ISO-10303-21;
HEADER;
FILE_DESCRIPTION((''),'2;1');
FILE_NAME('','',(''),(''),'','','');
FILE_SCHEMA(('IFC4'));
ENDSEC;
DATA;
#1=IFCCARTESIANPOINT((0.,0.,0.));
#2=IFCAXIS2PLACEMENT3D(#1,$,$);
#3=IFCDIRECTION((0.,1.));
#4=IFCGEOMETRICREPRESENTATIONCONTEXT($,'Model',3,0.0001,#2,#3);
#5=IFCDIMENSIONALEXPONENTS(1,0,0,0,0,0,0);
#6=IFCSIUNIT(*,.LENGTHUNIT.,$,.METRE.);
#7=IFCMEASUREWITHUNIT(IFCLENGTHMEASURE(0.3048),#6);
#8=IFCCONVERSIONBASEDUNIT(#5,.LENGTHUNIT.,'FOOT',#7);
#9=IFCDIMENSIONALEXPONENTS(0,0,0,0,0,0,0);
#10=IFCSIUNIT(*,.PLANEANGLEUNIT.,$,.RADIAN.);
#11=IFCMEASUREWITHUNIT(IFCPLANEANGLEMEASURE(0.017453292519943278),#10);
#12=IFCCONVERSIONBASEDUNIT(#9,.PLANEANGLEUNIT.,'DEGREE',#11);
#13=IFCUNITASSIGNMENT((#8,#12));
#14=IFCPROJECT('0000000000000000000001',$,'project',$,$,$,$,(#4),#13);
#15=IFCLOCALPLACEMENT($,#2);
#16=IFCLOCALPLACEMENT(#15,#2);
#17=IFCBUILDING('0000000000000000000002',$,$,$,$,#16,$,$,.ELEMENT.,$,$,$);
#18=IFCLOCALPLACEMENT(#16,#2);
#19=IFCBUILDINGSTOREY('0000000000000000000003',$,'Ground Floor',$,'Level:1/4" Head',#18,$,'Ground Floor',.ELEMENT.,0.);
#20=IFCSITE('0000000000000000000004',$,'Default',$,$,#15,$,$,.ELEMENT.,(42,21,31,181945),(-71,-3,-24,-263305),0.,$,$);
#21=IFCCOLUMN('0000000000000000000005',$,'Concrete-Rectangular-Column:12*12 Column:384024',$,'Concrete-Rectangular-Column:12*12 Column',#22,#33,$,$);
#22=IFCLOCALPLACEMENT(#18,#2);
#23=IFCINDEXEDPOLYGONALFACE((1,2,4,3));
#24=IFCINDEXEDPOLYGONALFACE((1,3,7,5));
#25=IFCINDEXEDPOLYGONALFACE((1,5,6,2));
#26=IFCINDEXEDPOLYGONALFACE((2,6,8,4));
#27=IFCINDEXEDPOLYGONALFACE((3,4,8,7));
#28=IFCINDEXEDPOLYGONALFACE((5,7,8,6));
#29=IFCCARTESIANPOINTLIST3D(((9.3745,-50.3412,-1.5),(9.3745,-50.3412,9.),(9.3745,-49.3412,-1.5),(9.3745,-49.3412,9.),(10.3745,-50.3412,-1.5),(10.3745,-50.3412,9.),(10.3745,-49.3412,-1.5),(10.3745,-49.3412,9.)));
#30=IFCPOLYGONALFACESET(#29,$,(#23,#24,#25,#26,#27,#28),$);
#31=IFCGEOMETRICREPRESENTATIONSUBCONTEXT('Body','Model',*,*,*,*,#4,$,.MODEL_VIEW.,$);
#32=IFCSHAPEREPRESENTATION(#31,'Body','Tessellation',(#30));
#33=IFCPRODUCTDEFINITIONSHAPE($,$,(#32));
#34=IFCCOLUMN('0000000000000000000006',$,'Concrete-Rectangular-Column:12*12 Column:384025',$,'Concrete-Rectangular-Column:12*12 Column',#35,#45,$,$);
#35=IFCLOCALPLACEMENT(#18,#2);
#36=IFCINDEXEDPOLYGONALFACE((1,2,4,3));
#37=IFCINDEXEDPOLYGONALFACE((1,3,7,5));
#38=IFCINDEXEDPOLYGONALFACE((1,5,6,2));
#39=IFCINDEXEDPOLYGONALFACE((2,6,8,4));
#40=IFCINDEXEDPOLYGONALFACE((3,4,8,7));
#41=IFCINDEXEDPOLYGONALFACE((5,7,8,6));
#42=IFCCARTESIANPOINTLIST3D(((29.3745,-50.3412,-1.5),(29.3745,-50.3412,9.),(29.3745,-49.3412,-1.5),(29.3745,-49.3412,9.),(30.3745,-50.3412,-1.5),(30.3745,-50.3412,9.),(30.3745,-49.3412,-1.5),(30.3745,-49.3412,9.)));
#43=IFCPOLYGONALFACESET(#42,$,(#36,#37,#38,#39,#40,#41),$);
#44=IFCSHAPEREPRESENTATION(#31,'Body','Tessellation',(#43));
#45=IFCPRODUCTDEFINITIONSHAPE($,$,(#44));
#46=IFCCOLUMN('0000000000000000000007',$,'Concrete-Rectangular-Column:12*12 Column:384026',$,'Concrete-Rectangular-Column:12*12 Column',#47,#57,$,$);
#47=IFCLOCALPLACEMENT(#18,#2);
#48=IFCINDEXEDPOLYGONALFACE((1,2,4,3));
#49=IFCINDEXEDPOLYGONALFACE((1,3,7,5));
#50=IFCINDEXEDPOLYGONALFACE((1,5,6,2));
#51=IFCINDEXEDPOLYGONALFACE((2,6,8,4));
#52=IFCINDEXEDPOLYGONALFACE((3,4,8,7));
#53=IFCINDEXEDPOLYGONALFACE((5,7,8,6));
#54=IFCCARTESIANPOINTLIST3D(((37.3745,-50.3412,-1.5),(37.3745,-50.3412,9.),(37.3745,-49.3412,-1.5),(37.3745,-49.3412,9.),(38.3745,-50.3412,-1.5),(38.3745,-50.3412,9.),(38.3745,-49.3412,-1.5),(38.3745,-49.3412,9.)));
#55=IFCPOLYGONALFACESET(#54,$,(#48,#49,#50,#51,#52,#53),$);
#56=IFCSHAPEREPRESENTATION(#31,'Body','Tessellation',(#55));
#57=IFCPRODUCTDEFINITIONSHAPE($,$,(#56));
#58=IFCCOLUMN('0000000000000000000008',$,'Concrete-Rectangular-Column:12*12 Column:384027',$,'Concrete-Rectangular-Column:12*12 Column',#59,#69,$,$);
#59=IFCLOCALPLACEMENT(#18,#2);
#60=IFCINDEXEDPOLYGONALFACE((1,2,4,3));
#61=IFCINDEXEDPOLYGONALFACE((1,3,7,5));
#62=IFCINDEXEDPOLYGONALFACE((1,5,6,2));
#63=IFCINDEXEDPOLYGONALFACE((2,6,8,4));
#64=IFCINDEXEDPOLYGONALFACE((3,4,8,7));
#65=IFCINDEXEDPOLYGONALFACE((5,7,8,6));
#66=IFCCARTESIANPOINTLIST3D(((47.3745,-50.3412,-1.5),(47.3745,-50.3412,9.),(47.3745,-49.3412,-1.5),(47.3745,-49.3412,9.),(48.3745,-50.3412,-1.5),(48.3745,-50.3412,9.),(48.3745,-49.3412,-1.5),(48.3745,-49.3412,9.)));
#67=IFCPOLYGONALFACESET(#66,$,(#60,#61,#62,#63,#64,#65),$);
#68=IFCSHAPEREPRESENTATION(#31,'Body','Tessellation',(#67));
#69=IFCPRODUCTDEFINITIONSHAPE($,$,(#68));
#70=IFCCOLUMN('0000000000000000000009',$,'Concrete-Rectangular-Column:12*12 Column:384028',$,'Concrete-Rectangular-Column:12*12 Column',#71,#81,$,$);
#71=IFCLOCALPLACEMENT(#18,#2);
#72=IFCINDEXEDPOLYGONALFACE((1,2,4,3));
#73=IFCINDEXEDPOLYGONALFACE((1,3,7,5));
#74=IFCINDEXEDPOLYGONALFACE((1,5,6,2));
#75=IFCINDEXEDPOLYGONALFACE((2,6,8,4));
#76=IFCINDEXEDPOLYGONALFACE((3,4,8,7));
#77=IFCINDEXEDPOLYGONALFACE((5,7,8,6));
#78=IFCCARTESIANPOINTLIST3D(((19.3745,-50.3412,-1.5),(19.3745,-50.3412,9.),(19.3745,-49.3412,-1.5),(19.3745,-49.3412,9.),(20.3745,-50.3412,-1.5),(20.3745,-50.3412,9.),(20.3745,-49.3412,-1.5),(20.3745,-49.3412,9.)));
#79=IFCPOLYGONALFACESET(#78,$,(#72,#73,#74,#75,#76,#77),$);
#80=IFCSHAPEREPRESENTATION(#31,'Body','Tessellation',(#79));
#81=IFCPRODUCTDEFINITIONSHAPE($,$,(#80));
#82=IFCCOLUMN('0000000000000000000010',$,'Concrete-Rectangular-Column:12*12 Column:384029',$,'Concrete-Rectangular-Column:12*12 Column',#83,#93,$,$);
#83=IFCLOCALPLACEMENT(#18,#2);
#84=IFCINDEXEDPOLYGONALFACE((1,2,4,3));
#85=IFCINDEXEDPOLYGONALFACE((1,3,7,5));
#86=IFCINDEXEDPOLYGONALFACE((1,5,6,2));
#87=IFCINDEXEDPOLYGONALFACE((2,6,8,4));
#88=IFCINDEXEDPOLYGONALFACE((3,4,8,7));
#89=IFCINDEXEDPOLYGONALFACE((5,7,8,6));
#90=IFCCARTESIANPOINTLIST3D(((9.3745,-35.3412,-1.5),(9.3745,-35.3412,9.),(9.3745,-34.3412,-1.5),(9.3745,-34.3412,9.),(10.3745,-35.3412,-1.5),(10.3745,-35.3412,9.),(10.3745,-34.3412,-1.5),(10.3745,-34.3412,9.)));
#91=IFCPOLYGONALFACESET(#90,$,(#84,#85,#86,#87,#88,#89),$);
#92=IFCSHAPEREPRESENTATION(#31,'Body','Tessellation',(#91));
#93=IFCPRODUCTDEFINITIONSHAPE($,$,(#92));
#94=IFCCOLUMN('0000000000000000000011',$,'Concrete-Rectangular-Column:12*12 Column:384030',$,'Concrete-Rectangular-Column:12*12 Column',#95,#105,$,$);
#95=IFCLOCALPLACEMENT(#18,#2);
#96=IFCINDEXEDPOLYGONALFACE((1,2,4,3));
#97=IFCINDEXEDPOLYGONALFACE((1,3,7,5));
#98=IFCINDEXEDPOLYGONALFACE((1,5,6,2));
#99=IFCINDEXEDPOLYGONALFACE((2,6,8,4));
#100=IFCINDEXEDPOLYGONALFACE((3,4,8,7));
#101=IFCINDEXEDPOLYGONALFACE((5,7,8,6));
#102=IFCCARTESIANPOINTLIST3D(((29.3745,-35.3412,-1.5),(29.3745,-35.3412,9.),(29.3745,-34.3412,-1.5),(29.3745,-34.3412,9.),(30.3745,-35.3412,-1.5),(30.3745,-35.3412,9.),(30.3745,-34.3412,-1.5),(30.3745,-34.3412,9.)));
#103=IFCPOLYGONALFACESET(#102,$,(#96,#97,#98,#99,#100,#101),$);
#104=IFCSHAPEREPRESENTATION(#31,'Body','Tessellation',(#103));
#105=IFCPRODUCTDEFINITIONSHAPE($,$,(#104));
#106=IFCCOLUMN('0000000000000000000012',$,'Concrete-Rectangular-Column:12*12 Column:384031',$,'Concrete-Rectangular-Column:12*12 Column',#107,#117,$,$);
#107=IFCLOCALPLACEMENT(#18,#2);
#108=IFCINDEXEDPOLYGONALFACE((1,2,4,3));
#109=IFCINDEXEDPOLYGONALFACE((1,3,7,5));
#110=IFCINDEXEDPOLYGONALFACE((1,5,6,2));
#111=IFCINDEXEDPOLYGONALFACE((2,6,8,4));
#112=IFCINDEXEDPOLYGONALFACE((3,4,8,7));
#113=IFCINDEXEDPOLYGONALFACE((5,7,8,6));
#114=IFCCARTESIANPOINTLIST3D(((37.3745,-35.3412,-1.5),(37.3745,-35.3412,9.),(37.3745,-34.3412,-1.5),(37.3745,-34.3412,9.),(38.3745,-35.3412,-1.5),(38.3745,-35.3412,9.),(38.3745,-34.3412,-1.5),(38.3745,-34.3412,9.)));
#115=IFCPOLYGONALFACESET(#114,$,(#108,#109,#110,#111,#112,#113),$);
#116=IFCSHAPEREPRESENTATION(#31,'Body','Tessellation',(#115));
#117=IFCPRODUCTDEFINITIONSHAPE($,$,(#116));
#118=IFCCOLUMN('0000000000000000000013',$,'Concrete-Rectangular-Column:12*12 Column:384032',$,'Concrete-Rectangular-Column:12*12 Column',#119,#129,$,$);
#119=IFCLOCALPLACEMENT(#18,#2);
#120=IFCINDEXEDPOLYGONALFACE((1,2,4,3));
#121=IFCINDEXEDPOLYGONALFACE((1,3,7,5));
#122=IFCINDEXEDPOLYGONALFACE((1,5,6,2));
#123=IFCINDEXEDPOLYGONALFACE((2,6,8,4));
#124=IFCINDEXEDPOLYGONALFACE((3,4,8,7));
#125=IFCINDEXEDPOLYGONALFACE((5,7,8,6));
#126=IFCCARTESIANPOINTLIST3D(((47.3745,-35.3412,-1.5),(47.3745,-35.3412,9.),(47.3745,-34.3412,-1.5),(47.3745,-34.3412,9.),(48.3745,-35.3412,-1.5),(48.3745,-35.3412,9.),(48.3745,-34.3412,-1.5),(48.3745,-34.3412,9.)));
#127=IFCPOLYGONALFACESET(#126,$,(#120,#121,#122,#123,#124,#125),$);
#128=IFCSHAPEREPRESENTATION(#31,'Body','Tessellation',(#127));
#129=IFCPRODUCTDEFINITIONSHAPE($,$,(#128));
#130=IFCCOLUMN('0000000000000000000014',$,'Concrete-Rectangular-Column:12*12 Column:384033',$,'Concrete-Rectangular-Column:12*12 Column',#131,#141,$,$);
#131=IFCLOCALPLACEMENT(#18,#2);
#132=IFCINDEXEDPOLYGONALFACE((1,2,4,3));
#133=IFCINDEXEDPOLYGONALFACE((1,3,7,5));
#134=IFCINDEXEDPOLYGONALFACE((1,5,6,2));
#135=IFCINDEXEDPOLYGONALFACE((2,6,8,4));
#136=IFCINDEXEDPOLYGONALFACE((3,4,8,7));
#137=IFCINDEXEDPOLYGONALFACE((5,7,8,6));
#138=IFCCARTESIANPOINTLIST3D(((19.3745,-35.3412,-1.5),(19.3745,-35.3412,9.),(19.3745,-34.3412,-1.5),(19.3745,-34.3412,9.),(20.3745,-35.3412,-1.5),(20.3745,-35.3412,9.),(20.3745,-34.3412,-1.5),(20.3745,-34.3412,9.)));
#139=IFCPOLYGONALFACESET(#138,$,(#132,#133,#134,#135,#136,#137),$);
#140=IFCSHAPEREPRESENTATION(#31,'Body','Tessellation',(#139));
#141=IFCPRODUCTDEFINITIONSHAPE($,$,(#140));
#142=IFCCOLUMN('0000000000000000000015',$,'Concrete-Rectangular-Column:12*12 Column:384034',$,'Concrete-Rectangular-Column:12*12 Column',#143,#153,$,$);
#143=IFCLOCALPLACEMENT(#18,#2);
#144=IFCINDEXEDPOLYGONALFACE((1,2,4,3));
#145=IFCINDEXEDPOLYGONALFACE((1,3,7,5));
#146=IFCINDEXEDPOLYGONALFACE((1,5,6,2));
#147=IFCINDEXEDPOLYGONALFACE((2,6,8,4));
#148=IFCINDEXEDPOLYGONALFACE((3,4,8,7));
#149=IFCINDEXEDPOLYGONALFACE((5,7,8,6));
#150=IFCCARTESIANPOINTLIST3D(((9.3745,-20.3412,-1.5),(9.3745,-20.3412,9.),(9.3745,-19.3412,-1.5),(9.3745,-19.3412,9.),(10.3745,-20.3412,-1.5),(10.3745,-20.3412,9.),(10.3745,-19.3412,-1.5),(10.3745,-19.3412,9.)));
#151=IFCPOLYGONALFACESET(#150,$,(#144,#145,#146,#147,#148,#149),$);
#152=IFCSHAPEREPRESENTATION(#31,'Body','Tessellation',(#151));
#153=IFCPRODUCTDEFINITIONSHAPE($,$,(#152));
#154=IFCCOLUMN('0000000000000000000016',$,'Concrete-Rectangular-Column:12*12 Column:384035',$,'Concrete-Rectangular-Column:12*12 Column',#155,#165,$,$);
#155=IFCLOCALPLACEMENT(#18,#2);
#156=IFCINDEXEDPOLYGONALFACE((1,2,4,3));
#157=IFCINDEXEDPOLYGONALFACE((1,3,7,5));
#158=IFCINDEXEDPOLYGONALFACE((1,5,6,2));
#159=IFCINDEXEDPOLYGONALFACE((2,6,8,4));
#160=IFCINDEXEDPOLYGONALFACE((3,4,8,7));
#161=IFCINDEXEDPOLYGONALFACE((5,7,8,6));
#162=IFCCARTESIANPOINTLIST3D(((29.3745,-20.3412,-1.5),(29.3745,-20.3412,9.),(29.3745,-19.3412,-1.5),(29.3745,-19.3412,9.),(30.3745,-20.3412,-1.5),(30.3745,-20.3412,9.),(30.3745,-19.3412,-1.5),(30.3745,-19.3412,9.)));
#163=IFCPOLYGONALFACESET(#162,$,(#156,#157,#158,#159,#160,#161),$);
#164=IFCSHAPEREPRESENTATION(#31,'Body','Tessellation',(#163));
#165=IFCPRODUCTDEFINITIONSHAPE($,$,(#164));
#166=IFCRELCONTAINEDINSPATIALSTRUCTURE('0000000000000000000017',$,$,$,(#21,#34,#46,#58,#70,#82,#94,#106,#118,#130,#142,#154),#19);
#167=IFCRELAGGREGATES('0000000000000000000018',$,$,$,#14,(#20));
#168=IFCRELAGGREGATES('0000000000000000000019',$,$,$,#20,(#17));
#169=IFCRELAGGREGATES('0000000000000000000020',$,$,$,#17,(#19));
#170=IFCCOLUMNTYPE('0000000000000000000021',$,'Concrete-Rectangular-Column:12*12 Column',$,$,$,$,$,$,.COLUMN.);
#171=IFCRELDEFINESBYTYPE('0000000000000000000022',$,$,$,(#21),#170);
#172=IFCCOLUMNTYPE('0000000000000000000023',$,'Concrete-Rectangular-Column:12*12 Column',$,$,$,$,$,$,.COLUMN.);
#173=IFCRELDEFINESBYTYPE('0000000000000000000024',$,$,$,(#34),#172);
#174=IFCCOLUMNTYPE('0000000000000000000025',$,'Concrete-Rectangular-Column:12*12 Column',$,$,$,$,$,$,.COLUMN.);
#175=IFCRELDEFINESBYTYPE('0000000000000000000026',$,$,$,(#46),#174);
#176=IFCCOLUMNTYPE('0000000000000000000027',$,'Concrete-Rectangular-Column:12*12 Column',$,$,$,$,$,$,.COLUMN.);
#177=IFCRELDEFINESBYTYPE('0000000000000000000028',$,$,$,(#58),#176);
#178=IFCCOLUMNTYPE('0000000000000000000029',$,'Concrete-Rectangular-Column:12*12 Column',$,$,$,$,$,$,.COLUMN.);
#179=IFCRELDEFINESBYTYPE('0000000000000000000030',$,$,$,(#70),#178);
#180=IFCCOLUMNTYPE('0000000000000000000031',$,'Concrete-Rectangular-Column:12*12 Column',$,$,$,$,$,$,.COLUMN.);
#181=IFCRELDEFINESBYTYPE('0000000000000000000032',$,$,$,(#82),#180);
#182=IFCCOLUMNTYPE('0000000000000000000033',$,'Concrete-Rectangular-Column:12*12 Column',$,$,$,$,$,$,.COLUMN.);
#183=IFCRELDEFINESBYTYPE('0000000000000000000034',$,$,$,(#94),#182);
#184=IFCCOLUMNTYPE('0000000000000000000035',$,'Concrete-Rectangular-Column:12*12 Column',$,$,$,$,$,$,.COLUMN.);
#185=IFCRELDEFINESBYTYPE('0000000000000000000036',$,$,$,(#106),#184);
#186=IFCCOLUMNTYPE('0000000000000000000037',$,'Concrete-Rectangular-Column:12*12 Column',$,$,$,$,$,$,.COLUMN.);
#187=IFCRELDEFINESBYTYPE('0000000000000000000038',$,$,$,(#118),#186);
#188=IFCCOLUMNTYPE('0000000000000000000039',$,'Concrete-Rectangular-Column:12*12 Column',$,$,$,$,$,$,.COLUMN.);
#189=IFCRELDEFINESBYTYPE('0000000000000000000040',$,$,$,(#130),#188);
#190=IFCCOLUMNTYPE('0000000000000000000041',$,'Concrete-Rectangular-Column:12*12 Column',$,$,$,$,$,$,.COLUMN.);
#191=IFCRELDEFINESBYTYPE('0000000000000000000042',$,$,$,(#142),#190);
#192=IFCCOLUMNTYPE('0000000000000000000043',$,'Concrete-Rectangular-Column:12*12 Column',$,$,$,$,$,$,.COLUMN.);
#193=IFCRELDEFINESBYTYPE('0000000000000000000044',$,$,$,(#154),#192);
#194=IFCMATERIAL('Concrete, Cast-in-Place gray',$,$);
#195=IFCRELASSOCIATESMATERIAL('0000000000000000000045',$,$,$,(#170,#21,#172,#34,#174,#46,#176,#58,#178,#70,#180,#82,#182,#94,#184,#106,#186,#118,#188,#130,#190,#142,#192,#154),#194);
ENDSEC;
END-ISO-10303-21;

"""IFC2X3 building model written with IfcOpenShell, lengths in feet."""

from ifc_helpers import new_model, entity, si_unit, converted_unit, direction, frame, frame_2d, origin, origin_2d_with_axis, place, context, subcontext, project, spatial, rectangle, extrude, source, transform, mapped, material, type_object, type_shapes, element, save


model = new_model("IFC2X3")

# Units and contexts
model_context = context("Model", 3, precision=0.0001, world=origin(), true_north=direction((0.0, 1.0)))
body_context = subcontext(model_context, "Body", "Model", "MODEL_VIEW")
ifc_project = project(units=[converted_unit("LENGTHUNIT", "FOOT", entity("IfcLengthMeasure", 0.3048), si_unit("LENGTHUNIT", "METRE"), dimensions=[1, 0, 0, 0, 0, 0, 0]), converted_unit("PLANEANGLEUNIT", "DEGREE", entity("IfcPlaneAngleMeasure", 0.017453292519943278), si_unit("PLANEANGLEUNIT", "RADIAN"), dimensions=[0, 0, 0, 0, 0, 0, 0])], contexts=[model_context])

# Site, building, storey
site_placement = place(None, origin())
site = spatial("IfcSite", under=ifc_project, at=site_placement, Name="Default", CompositionType="ELEMENT", RefLatitude=(42, 21, 31, 181945), RefLongitude=(-71, -3, -24, -263305), RefElevation=0.0)
building_placement = place(site_placement, origin())
building = spatial("IfcBuilding", under=site, at=building_placement, CompositionType="ELEMENT")
storey_placement = place(building_placement, origin())
storey = spatial("IfcBuildingStorey", under=building, at=storey_placement, Name="Ground Floor", ObjectType="Level:1/4\" Head", LongName="Ground Floor", CompositionType="ELEMENT", Elevation=0.0)

# Columns
ifc_material_1 = material(Name="Concrete, Cast-in-Place gray")
column_type_1 = type_object("IfcColumnType", Name="Concrete-Rectangular-Column:12*12 Column", PredefinedType="COLUMN", material=ifc_material_1)
shared_shape_1 = source(origin(), body_context, "Body", "SweptSolid", [
    extrude(rectangle(XDim=1.0, YDim=1.0, at=origin_2d_with_axis()), frame((9.8745, -49.8412, -1.5), z_axis=(0.0, 0.0, 1.0), x_axis=(-1.0, 0.0, 0.0)), (0.0, 0.0, 1.0), 10.5),
])
type_shapes(column_type_1, [shared_shape_1])
column_1_placement = place(storey_placement, origin())
element("IfcColumn", 1, at=column_1_placement, inside=storey, type_object=column_type_1, material=ifc_material_1, Name="Concrete-Rectangular-Column:12*12 Column:384024", ObjectType="Concrete-Rectangular-Column:12*12 Column", context=body_context, shape_type="MappedRepresentation", body=[
    mapped(shared_shape_1, transform((0.0, 0.0, 0.0), scale=1.0)),
])
column_type_2 = type_object("IfcColumnType", Name="Concrete-Rectangular-Column:12*12 Column", PredefinedType="COLUMN", material=ifc_material_1)
shared_shape_2 = source(origin(), body_context, "Body", "SweptSolid", [
    extrude(rectangle(XDim=1.0, YDim=1.0, at=frame_2d((0.0, 0.0), x_axis=(1.0, 0.0))), frame((29.8745, -49.8412, -1.5), z_axis=(0.0, 0.0, 1.0), x_axis=(-1.0, 0.0, 0.0)), (0.0, 0.0, 1.0), 10.5),
])
type_shapes(column_type_2, [shared_shape_2])
column_2_placement = place(storey_placement, origin())
element("IfcColumn", 2, at=column_2_placement, inside=storey, type_object=column_type_2, material=ifc_material_1, Name="Concrete-Rectangular-Column:12*12 Column:384025", ObjectType="Concrete-Rectangular-Column:12*12 Column", context=body_context, shape_type="MappedRepresentation", body=[
    mapped(shared_shape_2, transform((0.0, 0.0, 0.0), scale=1.0)),
])
column_type_3 = type_object("IfcColumnType", Name="Concrete-Rectangular-Column:12*12 Column", PredefinedType="COLUMN", material=ifc_material_1)
shared_shape_3 = source(origin(), body_context, "Body", "SweptSolid", [
    extrude(rectangle(XDim=1.0, YDim=1.0, at=origin_2d_with_axis()), frame((37.8745, -49.8412, -1.5), z_axis=(0.0, 0.0, 1.0), x_axis=(-1.0, 0.0, 0.0)), (0.0, 0.0, 1.0), 10.5),
])
type_shapes(column_type_3, [shared_shape_3])
column_3_placement = place(storey_placement, origin())
element("IfcColumn", 3, at=column_3_placement, inside=storey, type_object=column_type_3, material=ifc_material_1, Name="Concrete-Rectangular-Column:12*12 Column:384026", ObjectType="Concrete-Rectangular-Column:12*12 Column", context=body_context, shape_type="MappedRepresentation", body=[
    mapped(shared_shape_3, transform((0.0, 0.0, 0.0), scale=1.0)),
])
column_type_4 = type_object("IfcColumnType", Name="Concrete-Rectangular-Column:12*12 Column", PredefinedType="COLUMN", material=ifc_material_1)
shared_shape_4 = source(origin(), body_context, "Body", "SweptSolid", [
    extrude(rectangle(XDim=1.0, YDim=1.0, at=origin_2d_with_axis()), frame((47.8745, -49.8412, -1.5), z_axis=(0.0, 0.0, 1.0), x_axis=(-1.0, 0.0, 0.0)), (0.0, 0.0, 1.0), 10.5),
])
type_shapes(column_type_4, [shared_shape_4])
column_4_placement = place(storey_placement, origin())
element("IfcColumn", 4, at=column_4_placement, inside=storey, type_object=column_type_4, material=ifc_material_1, Name="Concrete-Rectangular-Column:12*12 Column:384027", ObjectType="Concrete-Rectangular-Column:12*12 Column", context=body_context, shape_type="MappedRepresentation", body=[
    mapped(shared_shape_4, transform((0.0, 0.0, 0.0), scale=1.0)),
])
column_type_5 = type_object("IfcColumnType", Name="Concrete-Rectangular-Column:12*12 Column", PredefinedType="COLUMN", material=ifc_material_1)
shared_shape_5 = source(origin(), body_context, "Body", "SweptSolid", [
    extrude(rectangle(XDim=1.0, YDim=1.0, at=frame_2d((0.0, 0.0), x_axis=(1.0, 0.0))), frame((19.8745, -49.8412, -1.5), z_axis=(0.0, 0.0, 1.0), x_axis=(-1.0, 0.0, 0.0)), (0.0, 0.0, 1.0), 10.5),
])
type_shapes(column_type_5, [shared_shape_5])
column_5_placement = place(storey_placement, origin())
element("IfcColumn", 5, at=column_5_placement, inside=storey, type_object=column_type_5, material=ifc_material_1, Name="Concrete-Rectangular-Column:12*12 Column:384028", ObjectType="Concrete-Rectangular-Column:12*12 Column", context=body_context, shape_type="MappedRepresentation", body=[
    mapped(shared_shape_5, transform((0.0, 0.0, 0.0), scale=1.0)),
])
column_type_6 = type_object("IfcColumnType", Name="Concrete-Rectangular-Column:12*12 Column", PredefinedType="COLUMN", material=ifc_material_1)
shared_shape_6 = source(origin(), body_context, "Body", "SweptSolid", [
    extrude(rectangle(XDim=1.0, YDim=1.0, at=origin_2d_with_axis()), frame((9.8745, -34.8412, -1.5), z_axis=(0.0, 0.0, 1.0), x_axis=(-1.0, 0.0, 0.0)), (0.0, 0.0, 1.0), 10.5),
])
type_shapes(column_type_6, [shared_shape_6])
column_6_placement = place(storey_placement, origin())
element("IfcColumn", 6, at=column_6_placement, inside=storey, type_object=column_type_6, material=ifc_material_1, Name="Concrete-Rectangular-Column:12*12 Column:384029", ObjectType="Concrete-Rectangular-Column:12*12 Column", context=body_context, shape_type="MappedRepresentation", body=[
    mapped(shared_shape_6, transform((0.0, 0.0, 0.0), scale=1.0)),
])
column_type_7 = type_object("IfcColumnType", Name="Concrete-Rectangular-Column:12*12 Column", PredefinedType="COLUMN", material=ifc_material_1)
shared_shape_7 = source(origin(), body_context, "Body", "SweptSolid", [
    extrude(rectangle(XDim=1.0, YDim=1.0, at=frame_2d((0.0, 0.0), x_axis=(1.0, 0.0))), frame((29.8745, -34.8412, -1.5), z_axis=(0.0, 0.0, 1.0), x_axis=(-1.0, 0.0, 0.0)), (0.0, 0.0, 1.0), 10.5),
])
type_shapes(column_type_7, [shared_shape_7])
column_7_placement = place(storey_placement, origin())
element("IfcColumn", 7, at=column_7_placement, inside=storey, type_object=column_type_7, material=ifc_material_1, Name="Concrete-Rectangular-Column:12*12 Column:384030", ObjectType="Concrete-Rectangular-Column:12*12 Column", context=body_context, shape_type="MappedRepresentation", body=[
    mapped(shared_shape_7, transform((0.0, 0.0, 0.0), scale=1.0)),
])
column_type_8 = type_object("IfcColumnType", Name="Concrete-Rectangular-Column:12*12 Column", PredefinedType="COLUMN", material=ifc_material_1)
shared_shape_8 = source(origin(), body_context, "Body", "SweptSolid", [
    extrude(rectangle(XDim=1.0, YDim=1.0, at=origin_2d_with_axis()), frame((37.8745, -34.8412, -1.5), z_axis=(0.0, 0.0, 1.0), x_axis=(-1.0, 0.0, 0.0)), (0.0, 0.0, 1.0), 10.5),
])
type_shapes(column_type_8, [shared_shape_8])
column_8_placement = place(storey_placement, origin())
element("IfcColumn", 8, at=column_8_placement, inside=storey, type_object=column_type_8, material=ifc_material_1, Name="Concrete-Rectangular-Column:12*12 Column:384031", ObjectType="Concrete-Rectangular-Column:12*12 Column", context=body_context, shape_type="MappedRepresentation", body=[
    mapped(shared_shape_8, transform((0.0, 0.0, 0.0), scale=1.0)),
])
column_type_9 = type_object("IfcColumnType", Name="Concrete-Rectangular-Column:12*12 Column", PredefinedType="COLUMN", material=ifc_material_1)
shared_shape_9 = source(origin(), body_context, "Body", "SweptSolid", [
    extrude(rectangle(XDim=1.0, YDim=1.0, at=origin_2d_with_axis()), frame((47.8745, -34.8412, -1.5), z_axis=(0.0, 0.0, 1.0), x_axis=(-1.0, 0.0, 0.0)), (0.0, 0.0, 1.0), 10.5),
])
type_shapes(column_type_9, [shared_shape_9])
column_9_placement = place(storey_placement, origin())
element("IfcColumn", 9, at=column_9_placement, inside=storey, type_object=column_type_9, material=ifc_material_1, Name="Concrete-Rectangular-Column:12*12 Column:384032", ObjectType="Concrete-Rectangular-Column:12*12 Column", context=body_context, shape_type="MappedRepresentation", body=[
    mapped(shared_shape_9, transform((0.0, 0.0, 0.0), scale=1.0)),
])
column_type_10 = type_object("IfcColumnType", Name="Concrete-Rectangular-Column:12*12 Column", PredefinedType="COLUMN", material=ifc_material_1)
shared_shape_10 = source(origin(), body_context, "Body", "SweptSolid", [
    extrude(rectangle(XDim=1.0, YDim=1.0, at=frame_2d((0.0, 0.0), x_axis=(1.0, 0.0))), frame((19.8745, -34.8412, -1.5), z_axis=(0.0, 0.0, 1.0), x_axis=(-1.0, 0.0, 0.0)), (0.0, 0.0, 1.0), 10.5),
])
type_shapes(column_type_10, [shared_shape_10])
column_10_placement = place(storey_placement, origin())
element("IfcColumn", 10, at=column_10_placement, inside=storey, type_object=column_type_10, material=ifc_material_1, Name="Concrete-Rectangular-Column:12*12 Column:384033", ObjectType="Concrete-Rectangular-Column:12*12 Column", context=body_context, shape_type="MappedRepresentation", body=[
    mapped(shared_shape_10, transform((0.0, 0.0, 0.0), scale=1.0)),
])
column_type_11 = type_object("IfcColumnType", Name="Concrete-Rectangular-Column:12*12 Column", PredefinedType="COLUMN", material=ifc_material_1)
shared_shape_11 = source(origin(), body_context, "Body", "SweptSolid", [
    extrude(rectangle(XDim=1.0, YDim=1.0, at=frame_2d((0.0, 0.0), x_axis=(1.0, 0.0))), frame((9.8745, -19.8412, -1.5), z_axis=(0.0, 0.0, 1.0), x_axis=(-1.0, 0.0, 0.0)), (0.0, 0.0, 1.0), 10.5),
])
type_shapes(column_type_11, [shared_shape_11])
column_11_placement = place(storey_placement, origin())
element("IfcColumn", 11, at=column_11_placement, inside=storey, type_object=column_type_11, material=ifc_material_1, Name="Concrete-Rectangular-Column:12*12 Column:384034", ObjectType="Concrete-Rectangular-Column:12*12 Column", context=body_context, shape_type="MappedRepresentation", body=[
    mapped(shared_shape_11, transform((0.0, 0.0, 0.0), scale=1.0)),
])
column_type_12 = type_object("IfcColumnType", Name="Concrete-Rectangular-Column:12*12 Column", PredefinedType="COLUMN", material=ifc_material_1)
shared_shape_12 = source(origin(), body_context, "Body", "SweptSolid", [
    extrude(rectangle(XDim=1.0, YDim=1.0, at=frame_2d((0.0, 0.0), x_axis=(1.0, 0.0))), frame((29.8745, -19.8412, -1.5), z_axis=(0.0, 0.0, 1.0), x_axis=(-1.0, 0.0, 0.0)), (0.0, 0.0, 1.0), 10.5),
])
type_shapes(column_type_12, [shared_shape_12])
column_12_placement = place(storey_placement, origin())
element("IfcColumn", 12, at=column_12_placement, inside=storey, type_object=column_type_12, material=ifc_material_1, Name="Concrete-Rectangular-Column:12*12 Column:384035", ObjectType="Concrete-Rectangular-Column:12*12 Column", context=body_context, shape_type="MappedRepresentation", body=[
    mapped(shared_shape_12, transform((0.0, 0.0, 0.0), scale=1.0)),
])

save(model, "model.ifc")
